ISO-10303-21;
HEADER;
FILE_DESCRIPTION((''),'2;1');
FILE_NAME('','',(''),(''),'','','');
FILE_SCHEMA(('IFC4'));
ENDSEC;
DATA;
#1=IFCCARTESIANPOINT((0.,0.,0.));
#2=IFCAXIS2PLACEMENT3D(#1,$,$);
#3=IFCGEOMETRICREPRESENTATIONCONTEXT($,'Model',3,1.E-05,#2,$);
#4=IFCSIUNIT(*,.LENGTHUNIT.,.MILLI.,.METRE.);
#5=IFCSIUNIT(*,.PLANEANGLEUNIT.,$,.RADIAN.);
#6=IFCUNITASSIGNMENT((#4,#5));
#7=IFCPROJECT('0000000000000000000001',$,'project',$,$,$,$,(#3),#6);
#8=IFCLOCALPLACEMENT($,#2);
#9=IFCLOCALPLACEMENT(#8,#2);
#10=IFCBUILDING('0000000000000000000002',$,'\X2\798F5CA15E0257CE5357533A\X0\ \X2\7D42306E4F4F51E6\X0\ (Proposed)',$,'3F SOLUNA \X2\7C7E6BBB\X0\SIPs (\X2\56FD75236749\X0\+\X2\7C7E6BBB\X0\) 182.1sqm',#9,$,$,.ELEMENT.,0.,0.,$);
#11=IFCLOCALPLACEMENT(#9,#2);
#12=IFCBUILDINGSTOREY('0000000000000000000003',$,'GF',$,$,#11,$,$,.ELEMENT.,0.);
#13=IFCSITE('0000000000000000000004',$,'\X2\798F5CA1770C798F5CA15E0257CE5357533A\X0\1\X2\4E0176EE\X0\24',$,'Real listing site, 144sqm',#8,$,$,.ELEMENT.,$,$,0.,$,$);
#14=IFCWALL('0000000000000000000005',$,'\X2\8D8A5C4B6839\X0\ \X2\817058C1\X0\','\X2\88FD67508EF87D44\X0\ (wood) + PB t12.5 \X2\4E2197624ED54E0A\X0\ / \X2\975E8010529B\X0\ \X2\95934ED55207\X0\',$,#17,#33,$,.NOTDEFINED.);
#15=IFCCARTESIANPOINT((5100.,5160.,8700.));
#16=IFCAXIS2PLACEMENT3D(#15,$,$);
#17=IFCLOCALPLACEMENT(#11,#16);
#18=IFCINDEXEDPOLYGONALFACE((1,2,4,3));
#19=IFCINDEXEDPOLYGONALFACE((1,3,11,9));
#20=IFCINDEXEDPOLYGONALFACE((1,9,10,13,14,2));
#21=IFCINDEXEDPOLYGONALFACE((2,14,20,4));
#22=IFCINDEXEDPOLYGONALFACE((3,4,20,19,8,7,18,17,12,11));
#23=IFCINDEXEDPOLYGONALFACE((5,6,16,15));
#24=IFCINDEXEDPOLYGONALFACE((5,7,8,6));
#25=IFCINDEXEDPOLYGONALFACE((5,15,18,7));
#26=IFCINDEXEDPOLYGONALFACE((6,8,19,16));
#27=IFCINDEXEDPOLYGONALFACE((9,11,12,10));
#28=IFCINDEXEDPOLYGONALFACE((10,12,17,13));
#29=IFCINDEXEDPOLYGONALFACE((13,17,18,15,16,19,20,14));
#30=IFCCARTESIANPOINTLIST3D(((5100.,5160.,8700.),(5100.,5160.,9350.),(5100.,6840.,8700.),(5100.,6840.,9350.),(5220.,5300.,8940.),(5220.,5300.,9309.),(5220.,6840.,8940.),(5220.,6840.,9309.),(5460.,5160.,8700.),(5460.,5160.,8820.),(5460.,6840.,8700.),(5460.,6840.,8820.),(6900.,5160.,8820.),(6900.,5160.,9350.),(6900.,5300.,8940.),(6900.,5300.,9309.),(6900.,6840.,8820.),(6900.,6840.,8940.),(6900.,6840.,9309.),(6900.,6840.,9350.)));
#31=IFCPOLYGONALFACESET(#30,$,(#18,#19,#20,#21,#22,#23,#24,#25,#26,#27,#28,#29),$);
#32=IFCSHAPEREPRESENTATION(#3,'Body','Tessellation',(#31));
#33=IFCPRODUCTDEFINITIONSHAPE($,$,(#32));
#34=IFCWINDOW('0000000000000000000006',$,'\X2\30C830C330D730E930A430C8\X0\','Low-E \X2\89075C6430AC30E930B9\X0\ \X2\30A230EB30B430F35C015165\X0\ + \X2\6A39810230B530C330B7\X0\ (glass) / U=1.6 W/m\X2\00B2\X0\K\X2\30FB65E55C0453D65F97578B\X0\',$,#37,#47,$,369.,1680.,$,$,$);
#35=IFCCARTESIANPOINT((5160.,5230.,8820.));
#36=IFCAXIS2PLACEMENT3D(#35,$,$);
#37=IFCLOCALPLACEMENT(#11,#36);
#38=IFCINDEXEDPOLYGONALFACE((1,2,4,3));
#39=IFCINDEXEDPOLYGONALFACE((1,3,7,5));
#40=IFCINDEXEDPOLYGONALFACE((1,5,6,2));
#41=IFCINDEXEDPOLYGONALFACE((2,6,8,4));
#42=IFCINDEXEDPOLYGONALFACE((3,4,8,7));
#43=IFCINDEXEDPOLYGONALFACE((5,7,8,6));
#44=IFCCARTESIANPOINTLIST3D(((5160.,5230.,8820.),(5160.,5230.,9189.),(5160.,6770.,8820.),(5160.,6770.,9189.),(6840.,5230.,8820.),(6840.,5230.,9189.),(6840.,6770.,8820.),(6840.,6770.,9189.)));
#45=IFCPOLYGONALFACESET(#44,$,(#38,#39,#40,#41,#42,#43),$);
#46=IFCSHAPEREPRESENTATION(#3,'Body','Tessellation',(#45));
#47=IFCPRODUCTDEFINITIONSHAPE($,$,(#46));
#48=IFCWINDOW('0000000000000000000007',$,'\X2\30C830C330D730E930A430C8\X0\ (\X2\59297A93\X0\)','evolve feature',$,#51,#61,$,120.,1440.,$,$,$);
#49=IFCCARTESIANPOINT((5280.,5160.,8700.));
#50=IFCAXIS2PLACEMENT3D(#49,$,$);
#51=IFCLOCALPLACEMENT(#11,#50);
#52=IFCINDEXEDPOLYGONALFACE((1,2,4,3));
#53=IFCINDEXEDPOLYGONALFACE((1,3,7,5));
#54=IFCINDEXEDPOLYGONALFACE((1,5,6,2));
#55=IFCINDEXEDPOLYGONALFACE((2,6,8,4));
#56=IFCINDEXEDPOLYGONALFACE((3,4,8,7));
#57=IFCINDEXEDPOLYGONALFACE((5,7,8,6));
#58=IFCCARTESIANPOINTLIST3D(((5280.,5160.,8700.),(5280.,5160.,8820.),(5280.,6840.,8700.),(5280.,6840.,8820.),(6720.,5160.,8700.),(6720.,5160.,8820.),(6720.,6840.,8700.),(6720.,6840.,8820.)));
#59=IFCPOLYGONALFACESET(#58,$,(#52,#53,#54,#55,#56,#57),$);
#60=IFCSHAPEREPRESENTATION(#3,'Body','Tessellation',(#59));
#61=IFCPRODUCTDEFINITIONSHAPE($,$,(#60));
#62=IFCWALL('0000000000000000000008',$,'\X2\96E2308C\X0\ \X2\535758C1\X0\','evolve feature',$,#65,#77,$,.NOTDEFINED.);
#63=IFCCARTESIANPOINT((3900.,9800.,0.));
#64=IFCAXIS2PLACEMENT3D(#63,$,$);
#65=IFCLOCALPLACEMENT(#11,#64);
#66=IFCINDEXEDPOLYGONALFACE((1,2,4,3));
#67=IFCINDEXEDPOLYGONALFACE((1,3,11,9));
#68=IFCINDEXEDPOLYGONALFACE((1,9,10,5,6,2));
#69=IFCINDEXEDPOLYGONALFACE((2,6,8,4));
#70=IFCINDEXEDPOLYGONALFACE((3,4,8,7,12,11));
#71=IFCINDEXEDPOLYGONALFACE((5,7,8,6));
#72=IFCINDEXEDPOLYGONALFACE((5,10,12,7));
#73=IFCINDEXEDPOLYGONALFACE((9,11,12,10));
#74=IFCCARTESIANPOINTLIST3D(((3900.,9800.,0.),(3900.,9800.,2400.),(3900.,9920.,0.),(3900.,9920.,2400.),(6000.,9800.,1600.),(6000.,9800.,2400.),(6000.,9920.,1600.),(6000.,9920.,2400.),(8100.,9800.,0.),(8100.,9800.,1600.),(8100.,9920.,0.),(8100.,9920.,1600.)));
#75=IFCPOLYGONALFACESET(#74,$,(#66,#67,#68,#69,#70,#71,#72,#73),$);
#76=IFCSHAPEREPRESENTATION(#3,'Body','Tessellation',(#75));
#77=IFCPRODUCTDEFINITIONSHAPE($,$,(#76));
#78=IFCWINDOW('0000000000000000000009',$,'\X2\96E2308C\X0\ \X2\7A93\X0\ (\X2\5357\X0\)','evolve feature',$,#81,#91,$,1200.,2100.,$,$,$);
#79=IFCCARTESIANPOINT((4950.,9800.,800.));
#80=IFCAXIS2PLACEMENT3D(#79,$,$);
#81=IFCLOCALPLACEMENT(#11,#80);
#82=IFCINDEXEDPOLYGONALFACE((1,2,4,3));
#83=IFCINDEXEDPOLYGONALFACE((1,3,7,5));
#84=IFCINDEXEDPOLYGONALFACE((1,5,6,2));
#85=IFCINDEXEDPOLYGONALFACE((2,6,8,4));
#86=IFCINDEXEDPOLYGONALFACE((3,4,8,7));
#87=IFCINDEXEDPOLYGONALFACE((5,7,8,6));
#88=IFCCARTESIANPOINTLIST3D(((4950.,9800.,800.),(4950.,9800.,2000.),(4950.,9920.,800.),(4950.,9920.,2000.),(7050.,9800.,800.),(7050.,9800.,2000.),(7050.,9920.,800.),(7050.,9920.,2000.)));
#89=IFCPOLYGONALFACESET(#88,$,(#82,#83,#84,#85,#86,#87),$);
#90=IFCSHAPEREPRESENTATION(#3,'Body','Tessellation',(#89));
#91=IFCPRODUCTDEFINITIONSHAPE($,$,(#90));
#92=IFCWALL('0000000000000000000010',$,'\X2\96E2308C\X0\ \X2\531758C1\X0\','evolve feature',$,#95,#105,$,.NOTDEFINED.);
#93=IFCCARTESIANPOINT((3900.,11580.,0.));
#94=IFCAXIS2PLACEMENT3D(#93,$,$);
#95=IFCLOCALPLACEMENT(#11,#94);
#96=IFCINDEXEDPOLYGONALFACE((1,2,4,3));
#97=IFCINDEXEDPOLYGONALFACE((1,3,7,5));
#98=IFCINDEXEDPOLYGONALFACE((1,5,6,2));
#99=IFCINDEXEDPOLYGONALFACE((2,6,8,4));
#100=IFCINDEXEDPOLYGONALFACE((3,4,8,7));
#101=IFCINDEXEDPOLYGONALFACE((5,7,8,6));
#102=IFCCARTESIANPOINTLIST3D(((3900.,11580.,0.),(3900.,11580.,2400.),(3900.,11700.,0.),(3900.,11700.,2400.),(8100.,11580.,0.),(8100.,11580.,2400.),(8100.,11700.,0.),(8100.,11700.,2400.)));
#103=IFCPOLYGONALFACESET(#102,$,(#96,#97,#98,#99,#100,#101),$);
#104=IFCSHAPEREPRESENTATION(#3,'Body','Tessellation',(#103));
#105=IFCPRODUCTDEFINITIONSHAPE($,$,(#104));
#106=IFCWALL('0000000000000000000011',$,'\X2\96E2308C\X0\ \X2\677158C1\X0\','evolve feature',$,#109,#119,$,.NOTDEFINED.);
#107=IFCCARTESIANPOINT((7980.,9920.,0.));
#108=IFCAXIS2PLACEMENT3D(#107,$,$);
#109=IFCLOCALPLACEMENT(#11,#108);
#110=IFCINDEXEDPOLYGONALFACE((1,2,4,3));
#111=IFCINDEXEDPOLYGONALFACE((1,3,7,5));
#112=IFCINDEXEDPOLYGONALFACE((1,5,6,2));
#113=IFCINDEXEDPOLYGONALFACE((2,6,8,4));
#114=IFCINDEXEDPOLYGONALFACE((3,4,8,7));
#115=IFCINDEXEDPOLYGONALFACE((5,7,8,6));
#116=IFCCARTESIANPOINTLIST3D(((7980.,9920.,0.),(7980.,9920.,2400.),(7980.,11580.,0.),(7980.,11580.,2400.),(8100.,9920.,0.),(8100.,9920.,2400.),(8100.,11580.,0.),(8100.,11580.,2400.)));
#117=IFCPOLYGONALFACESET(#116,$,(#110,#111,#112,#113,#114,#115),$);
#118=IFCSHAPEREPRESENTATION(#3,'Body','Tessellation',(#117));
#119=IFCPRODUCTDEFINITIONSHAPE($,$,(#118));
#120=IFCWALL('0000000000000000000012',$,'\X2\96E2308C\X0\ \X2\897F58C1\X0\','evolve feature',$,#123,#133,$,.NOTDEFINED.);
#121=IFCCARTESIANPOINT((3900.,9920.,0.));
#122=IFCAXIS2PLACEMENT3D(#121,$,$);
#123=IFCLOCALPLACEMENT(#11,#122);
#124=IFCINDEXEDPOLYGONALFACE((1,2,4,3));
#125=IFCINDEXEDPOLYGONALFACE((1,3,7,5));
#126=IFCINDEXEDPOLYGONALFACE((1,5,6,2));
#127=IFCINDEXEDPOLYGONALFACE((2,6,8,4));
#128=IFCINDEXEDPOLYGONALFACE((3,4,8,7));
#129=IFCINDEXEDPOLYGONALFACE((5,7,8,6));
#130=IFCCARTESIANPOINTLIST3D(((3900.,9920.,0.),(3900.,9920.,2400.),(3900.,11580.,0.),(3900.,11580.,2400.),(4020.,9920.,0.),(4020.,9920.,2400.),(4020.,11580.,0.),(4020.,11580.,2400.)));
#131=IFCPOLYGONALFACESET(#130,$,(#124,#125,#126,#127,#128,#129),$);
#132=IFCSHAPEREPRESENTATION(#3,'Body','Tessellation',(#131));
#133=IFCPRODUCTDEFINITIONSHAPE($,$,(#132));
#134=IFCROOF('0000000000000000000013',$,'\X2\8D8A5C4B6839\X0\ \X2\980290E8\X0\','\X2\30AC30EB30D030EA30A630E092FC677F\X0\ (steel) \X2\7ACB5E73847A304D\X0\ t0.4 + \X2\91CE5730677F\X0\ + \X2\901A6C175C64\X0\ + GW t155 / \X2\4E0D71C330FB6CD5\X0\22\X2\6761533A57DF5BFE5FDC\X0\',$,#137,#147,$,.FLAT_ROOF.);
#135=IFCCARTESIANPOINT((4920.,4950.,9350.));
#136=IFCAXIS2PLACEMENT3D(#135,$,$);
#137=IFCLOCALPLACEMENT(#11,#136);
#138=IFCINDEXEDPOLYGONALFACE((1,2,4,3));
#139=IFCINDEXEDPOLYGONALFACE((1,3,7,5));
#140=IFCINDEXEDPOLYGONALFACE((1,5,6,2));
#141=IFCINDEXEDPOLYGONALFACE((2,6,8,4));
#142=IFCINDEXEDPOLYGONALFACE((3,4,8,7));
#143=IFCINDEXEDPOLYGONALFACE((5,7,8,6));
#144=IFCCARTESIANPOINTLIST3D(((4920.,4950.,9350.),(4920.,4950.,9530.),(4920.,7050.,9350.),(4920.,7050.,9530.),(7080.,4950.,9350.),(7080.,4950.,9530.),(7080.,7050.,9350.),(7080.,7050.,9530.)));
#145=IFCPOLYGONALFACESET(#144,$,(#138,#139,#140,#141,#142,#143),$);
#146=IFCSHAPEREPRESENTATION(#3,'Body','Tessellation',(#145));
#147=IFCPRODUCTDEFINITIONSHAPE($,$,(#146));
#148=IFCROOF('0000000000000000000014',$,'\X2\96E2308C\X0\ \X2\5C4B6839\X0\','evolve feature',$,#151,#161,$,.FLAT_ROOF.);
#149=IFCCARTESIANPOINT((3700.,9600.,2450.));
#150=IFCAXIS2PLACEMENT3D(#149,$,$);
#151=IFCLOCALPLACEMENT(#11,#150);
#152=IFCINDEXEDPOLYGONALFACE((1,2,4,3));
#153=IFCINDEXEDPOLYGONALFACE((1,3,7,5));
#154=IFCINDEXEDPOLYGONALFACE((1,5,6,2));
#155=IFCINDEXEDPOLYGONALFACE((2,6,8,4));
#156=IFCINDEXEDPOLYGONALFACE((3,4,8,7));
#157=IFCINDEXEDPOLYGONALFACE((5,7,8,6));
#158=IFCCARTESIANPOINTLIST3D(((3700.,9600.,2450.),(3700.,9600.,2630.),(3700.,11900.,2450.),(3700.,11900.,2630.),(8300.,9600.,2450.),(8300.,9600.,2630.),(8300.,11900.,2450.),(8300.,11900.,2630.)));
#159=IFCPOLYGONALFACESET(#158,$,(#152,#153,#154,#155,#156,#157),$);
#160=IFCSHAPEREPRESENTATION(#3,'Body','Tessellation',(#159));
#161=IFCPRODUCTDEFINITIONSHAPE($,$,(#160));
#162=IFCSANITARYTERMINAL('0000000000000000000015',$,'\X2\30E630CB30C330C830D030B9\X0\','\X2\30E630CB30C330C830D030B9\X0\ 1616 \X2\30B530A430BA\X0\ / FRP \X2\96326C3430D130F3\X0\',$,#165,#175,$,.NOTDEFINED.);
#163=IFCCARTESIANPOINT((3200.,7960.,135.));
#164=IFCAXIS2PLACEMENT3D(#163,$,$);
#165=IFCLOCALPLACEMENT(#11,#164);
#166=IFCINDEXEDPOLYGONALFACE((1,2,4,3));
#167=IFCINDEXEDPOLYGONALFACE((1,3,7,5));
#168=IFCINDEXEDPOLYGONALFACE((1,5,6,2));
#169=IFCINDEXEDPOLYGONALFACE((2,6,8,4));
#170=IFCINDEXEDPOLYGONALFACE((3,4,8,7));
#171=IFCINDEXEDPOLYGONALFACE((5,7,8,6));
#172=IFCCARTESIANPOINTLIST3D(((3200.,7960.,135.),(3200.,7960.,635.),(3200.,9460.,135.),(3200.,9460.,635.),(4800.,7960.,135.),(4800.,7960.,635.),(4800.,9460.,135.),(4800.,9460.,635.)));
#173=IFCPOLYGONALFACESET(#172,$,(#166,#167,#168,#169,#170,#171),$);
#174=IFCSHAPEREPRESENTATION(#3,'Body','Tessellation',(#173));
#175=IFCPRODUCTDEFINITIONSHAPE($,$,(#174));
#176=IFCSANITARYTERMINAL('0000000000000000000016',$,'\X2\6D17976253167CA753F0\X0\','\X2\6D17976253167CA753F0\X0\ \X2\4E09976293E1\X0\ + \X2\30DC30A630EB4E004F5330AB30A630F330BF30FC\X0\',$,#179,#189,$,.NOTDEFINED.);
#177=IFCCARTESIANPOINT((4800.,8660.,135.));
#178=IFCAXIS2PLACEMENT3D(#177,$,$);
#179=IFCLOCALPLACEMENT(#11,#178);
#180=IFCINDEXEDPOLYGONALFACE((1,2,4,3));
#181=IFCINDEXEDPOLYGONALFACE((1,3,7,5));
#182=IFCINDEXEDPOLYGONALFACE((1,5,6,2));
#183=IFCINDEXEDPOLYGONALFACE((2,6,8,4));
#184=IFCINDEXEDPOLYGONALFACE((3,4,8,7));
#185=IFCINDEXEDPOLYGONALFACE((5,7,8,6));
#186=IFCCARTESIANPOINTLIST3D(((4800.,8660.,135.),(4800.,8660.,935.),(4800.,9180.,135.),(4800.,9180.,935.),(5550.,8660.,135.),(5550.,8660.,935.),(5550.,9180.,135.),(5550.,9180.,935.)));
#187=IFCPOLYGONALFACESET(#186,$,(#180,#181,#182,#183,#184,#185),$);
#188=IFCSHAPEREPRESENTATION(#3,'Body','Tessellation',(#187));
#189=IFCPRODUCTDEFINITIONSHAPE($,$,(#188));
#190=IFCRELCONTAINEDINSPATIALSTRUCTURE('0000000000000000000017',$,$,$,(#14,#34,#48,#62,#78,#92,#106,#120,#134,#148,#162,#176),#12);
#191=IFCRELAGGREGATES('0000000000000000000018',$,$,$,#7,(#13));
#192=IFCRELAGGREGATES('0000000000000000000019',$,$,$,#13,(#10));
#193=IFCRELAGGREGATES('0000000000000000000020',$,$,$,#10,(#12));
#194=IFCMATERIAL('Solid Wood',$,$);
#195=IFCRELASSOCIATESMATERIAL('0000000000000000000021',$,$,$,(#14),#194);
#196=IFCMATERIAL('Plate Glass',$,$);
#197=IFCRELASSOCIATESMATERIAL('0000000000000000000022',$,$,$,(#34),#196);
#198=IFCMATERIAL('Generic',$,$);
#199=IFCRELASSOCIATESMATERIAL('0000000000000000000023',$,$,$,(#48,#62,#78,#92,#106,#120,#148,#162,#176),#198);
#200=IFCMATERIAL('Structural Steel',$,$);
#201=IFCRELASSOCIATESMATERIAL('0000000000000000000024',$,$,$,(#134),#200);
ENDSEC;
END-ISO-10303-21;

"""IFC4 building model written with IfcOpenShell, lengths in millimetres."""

from ifc_helpers import new_model, si_unit, frame, frame_2d, origin, place, context, project, spatial, rectangle, extrude, material, element, fill, save


model = new_model("IFC4")

# Units and contexts
model_context = context("Model", 3, precision=1e-05, world=origin())
ifc_project = project(units=[si_unit("LENGTHUNIT", "METRE", prefix="MILLI"), si_unit("PLANEANGLEUNIT", "RADIAN")], contexts=[model_context])

# Site, building, storey
site_placement = place(None, origin())
site = spatial("IfcSite", under=ifc_project, at=site_placement, Name="福岡県福岡市城南区1丁目24", ObjectType="Real listing site, 144sqm", CompositionType="ELEMENT", RefElevation=0.0)
building_placement = place(site_placement, origin())
building = spatial("IfcBuilding", under=site, at=building_placement, Name="福岡市城南区 終の住処 (Proposed)", ObjectType="3F SOLUNA 籾殻SIPs (国産杉+籾殻) 182.1sqm", CompositionType="ELEMENT", ElevationOfRefHeight=0.0, ElevationOfTerrain=0.0)
storey_placement = place(building_placement, origin())
storey = spatial("IfcBuildingStorey", under=building, at=storey_placement, Name="GF", CompositionType="ELEMENT", Elevation=0.0)

# Shared definitions
ifc_material_1 = material(Name="Generic")

# Shared definitions
ifc_material_2 = material(Name="Solid Wood")
ifc_material_3 = material(Name="Plate Glass")

# Wall, openings, windows
wall_1_placement = place(storey_placement, frame((5100.0, 5160.0, 8700.0)))
wall_1 = element("IfcWall", 1, at=wall_1_placement, inside=storey, material=ifc_material_2, Name="越屋根 腰壁", Description="製材軸組 (wood) + PB t12.5 両面仕上 / 非耐力 間仕切", PredefinedType="NOTDEFINED", context=model_context, shape_type="SweptSolid", body=[
    extrude(rectangle(XDim=1800.0, YDim=1680.0, at=frame_2d((900.0, 840.0))), frame((5100.0, 5160.0, 8700.0)), (0.0, 0.0, 1.0), 650.0),
])
opening_1_placement = place(storey_placement, frame((5160.0, 5230.0, 8820.0)))
opening_1 = element("IfcOpeningElement", 2, at=opening_1_placement, cuts=wall_1, PredefinedType="NOTDEFINED", context=model_context, shape_type="SweptSolid", body=[
    extrude(rectangle(XDim=1680.0, YDim=1540.0, at=frame_2d((840.0, 770.0))), frame((5160.0, 5230.0, 8820.0)), (0.0, 0.0, 1.0), 369.0),
])
opening_2_placement = place(storey_placement, frame((5280.0, 5160.0, 8700.0)))
opening_2 = element("IfcOpeningElement", 3, at=opening_2_placement, cuts=wall_1, PredefinedType="NOTDEFINED", context=model_context, shape_type="SweptSolid", body=[
    extrude(rectangle(XDim=1440.0, YDim=1680.0, at=frame_2d((720.0, 840.0))), frame((5280.0, 5160.0, 8700.0)), (0.0, 0.0, 1.0), 120.0),
])
window_1_placement = place(storey_placement, frame((5160.0, 5230.0, 8820.0)))
window_1 = element("IfcWindow", 4, at=window_1_placement, inside=storey, material=ifc_material_3, Name="トップライト", Description="Low-E 複層ガラス アルゴン封入 + 樹脂サッシ (glass) / U=1.6 W/m²K・日射取得型", OverallHeight=369.0, OverallWidth=1680.0, context=model_context, shape_type="SweptSolid", body=[
    extrude(rectangle(XDim=1680.0, YDim=1540.0, at=frame_2d((840.0, 770.0))), frame((5160.0, 5230.0, 8820.0)), (0.0, 0.0, 1.0), 369.0),
])
fill(opening_1, window_1)
window_2_placement = place(storey_placement, frame((5280.0, 5160.0, 8700.0)))
window_2 = element("IfcWindow", 5, at=window_2_placement, inside=storey, material=ifc_material_1, Name="トップライト (天窓)", Description="evolve feature", OverallHeight=120.0, OverallWidth=1440.0, context=model_context, shape_type="SweptSolid", body=[
    extrude(rectangle(XDim=1440.0, YDim=1680.0, at=frame_2d((720.0, 840.0))), frame((5280.0, 5160.0, 8700.0)), (0.0, 0.0, 1.0), 120.0),
])
fill(opening_2, window_2)

# Wall, opening, window
wall_2_placement = place(storey_placement, frame((3900.0, 9800.0, 0.0)))
wall_2 = element("IfcWall", 6, at=wall_2_placement, inside=storey, material=ifc_material_1, Name="離れ 南壁", Description="evolve feature", PredefinedType="NOTDEFINED", context=model_context, shape_type="SweptSolid", body=[
    extrude(rectangle(XDim=4200.0, YDim=120.0, at=frame_2d((2100.0, 60.0))), frame((3900.0, 9800.0, 0.0)), (0.0, 0.0, 1.0), 2400.0),
])
opening_3_placement = place(storey_placement, frame((4950.0, 9800.0, 800.0)))
opening_3 = element("IfcOpeningElement", 7, at=opening_3_placement, cuts=wall_2, PredefinedType="NOTDEFINED", context=model_context, shape_type="SweptSolid", body=[
    extrude(rectangle(XDim=2100.0, YDim=120.0, at=frame_2d((1050.0, 60.0))), frame((4950.0, 9800.0, 800.0)), (0.0, 0.0, 1.0), 1200.0),
])
window_3_placement = place(storey_placement, frame((4950.0, 9800.0, 800.0)))
window_3 = element("IfcWindow", 8, at=window_3_placement, inside=storey, material=ifc_material_1, Name="離れ 窓 (南)", Description="evolve feature", OverallHeight=1200.0, OverallWidth=2100.0, context=model_context, shape_type="SweptSolid", body=[
    extrude(rectangle(XDim=2100.0, YDim=120.0, at=frame_2d((1050.0, 60.0))), frame((4950.0, 9800.0, 800.0)), (0.0, 0.0, 1.0), 1200.0),
])
fill(opening_3, window_3)

# Walls
wall_3_placement = place(storey_placement, frame((3900.0, 11580.0, 0.0)))
element("IfcWall", 9, at=wall_3_placement, inside=storey, material=ifc_material_1, Name="離れ 北壁", Description="evolve feature", PredefinedType="NOTDEFINED", context=model_context, shape_type="SweptSolid", body=[
    extrude(rectangle(XDim=4200.0, YDim=120.0, at=frame_2d((2100.0, 60.0))), frame((3900.0, 11580.0, 0.0)), (0.0, 0.0, 1.0), 2400.0),
])
wall_4_placement = place(storey_placement, frame((7980.0, 9920.0, 0.0)))
element("IfcWall", 10, at=wall_4_placement, inside=storey, material=ifc_material_1, Name="離れ 東壁", Description="evolve feature", PredefinedType="NOTDEFINED", context=model_context, shape_type="SweptSolid", body=[
    extrude(rectangle(XDim=120.0, YDim=1660.0, at=frame_2d((60.0, 830.0))), frame((7980.0, 9920.0, 0.0)), (0.0, 0.0, 1.0), 2400.0),
])
wall_5_placement = place(storey_placement, frame((3900.0, 9920.0, 0.0)))
element("IfcWall", 11, at=wall_5_placement, inside=storey, material=ifc_material_1, Name="離れ 西壁", Description="evolve feature", PredefinedType="NOTDEFINED", context=model_context, shape_type="SweptSolid", body=[
    extrude(rectangle(XDim=120.0, YDim=1660.0, at=frame_2d((60.0, 830.0))), frame((3900.0, 9920.0, 0.0)), (0.0, 0.0, 1.0), 2400.0),
])

# Roofs
ifc_material_4 = material(Name="Structural Steel")
roof_1_placement = place(storey_placement, frame((4920.0, 4950.0, 9350.0)))
element("IfcRoof", 12, at=roof_1_placement, inside=storey, material=ifc_material_4, Name="越屋根 頂部", Description="ガルバリウム鋼板 (steel) 立平葺き t0.4 + 野地板 + 通気層 + GW t155 / 不燃・法22条区域対応", PredefinedType="FLAT_ROOF", context=model_context, shape_type="SweptSolid", body=[
    extrude(rectangle(XDim=2160.0, YDim=2100.0, at=frame_2d((1080.0, 1050.0))), frame((4920.0, 4950.0, 9350.0)), (0.0, 0.0, 1.0), 180.0),
])
roof_2_placement = place(storey_placement, frame((3700.0, 9600.0, 2450.0)))
element("IfcRoof", 13, at=roof_2_placement, inside=storey, material=ifc_material_1, Name="離れ 屋根", Description="evolve feature", PredefinedType="FLAT_ROOF", context=model_context, shape_type="SweptSolid", body=[
    extrude(rectangle(XDim=4600.0, YDim=2300.0, at=frame_2d((2300.0, 1150.0))), frame((3700.0, 9600.0, 2450.0)), (0.0, 0.0, 1.0), 180.0),
])

# Sanitary terminals
sanitary_terminal_1_placement = place(storey_placement, frame((3200.0, 7960.0, 135.0)))
element("IfcSanitaryTerminal", 14, at=sanitary_terminal_1_placement, inside=storey, material=ifc_material_1, Name="ユニットバス", Description="ユニットバス 1616 サイズ / FRP 防水パン", PredefinedType="NOTDEFINED", context=model_context, shape_type="SweptSolid", body=[
    extrude(rectangle(XDim=1600.0, YDim=1500.0, at=frame_2d((800.0, 750.0))), frame((3200.0, 7960.0, 135.0)), (0.0, 0.0, 1.0), 500.0),
])
sanitary_terminal_2_placement = place(storey_placement, frame((4800.0, 8660.0, 135.0)))
element("IfcSanitaryTerminal", 15, at=sanitary_terminal_2_placement, inside=storey, material=ifc_material_1, Name="洗面化粧台", Description="洗面化粧台 三面鏡 + ボウル一体カウンター", PredefinedType="NOTDEFINED", context=model_context, shape_type="SweptSolid", body=[
    extrude(rectangle(XDim=750.0, YDim=520.0, at=frame_2d((375.0, 260.0))), frame((4800.0, 8660.0, 135.0)), (0.0, 0.0, 1.0), 800.0),
])

save(model, "model.ifc")
